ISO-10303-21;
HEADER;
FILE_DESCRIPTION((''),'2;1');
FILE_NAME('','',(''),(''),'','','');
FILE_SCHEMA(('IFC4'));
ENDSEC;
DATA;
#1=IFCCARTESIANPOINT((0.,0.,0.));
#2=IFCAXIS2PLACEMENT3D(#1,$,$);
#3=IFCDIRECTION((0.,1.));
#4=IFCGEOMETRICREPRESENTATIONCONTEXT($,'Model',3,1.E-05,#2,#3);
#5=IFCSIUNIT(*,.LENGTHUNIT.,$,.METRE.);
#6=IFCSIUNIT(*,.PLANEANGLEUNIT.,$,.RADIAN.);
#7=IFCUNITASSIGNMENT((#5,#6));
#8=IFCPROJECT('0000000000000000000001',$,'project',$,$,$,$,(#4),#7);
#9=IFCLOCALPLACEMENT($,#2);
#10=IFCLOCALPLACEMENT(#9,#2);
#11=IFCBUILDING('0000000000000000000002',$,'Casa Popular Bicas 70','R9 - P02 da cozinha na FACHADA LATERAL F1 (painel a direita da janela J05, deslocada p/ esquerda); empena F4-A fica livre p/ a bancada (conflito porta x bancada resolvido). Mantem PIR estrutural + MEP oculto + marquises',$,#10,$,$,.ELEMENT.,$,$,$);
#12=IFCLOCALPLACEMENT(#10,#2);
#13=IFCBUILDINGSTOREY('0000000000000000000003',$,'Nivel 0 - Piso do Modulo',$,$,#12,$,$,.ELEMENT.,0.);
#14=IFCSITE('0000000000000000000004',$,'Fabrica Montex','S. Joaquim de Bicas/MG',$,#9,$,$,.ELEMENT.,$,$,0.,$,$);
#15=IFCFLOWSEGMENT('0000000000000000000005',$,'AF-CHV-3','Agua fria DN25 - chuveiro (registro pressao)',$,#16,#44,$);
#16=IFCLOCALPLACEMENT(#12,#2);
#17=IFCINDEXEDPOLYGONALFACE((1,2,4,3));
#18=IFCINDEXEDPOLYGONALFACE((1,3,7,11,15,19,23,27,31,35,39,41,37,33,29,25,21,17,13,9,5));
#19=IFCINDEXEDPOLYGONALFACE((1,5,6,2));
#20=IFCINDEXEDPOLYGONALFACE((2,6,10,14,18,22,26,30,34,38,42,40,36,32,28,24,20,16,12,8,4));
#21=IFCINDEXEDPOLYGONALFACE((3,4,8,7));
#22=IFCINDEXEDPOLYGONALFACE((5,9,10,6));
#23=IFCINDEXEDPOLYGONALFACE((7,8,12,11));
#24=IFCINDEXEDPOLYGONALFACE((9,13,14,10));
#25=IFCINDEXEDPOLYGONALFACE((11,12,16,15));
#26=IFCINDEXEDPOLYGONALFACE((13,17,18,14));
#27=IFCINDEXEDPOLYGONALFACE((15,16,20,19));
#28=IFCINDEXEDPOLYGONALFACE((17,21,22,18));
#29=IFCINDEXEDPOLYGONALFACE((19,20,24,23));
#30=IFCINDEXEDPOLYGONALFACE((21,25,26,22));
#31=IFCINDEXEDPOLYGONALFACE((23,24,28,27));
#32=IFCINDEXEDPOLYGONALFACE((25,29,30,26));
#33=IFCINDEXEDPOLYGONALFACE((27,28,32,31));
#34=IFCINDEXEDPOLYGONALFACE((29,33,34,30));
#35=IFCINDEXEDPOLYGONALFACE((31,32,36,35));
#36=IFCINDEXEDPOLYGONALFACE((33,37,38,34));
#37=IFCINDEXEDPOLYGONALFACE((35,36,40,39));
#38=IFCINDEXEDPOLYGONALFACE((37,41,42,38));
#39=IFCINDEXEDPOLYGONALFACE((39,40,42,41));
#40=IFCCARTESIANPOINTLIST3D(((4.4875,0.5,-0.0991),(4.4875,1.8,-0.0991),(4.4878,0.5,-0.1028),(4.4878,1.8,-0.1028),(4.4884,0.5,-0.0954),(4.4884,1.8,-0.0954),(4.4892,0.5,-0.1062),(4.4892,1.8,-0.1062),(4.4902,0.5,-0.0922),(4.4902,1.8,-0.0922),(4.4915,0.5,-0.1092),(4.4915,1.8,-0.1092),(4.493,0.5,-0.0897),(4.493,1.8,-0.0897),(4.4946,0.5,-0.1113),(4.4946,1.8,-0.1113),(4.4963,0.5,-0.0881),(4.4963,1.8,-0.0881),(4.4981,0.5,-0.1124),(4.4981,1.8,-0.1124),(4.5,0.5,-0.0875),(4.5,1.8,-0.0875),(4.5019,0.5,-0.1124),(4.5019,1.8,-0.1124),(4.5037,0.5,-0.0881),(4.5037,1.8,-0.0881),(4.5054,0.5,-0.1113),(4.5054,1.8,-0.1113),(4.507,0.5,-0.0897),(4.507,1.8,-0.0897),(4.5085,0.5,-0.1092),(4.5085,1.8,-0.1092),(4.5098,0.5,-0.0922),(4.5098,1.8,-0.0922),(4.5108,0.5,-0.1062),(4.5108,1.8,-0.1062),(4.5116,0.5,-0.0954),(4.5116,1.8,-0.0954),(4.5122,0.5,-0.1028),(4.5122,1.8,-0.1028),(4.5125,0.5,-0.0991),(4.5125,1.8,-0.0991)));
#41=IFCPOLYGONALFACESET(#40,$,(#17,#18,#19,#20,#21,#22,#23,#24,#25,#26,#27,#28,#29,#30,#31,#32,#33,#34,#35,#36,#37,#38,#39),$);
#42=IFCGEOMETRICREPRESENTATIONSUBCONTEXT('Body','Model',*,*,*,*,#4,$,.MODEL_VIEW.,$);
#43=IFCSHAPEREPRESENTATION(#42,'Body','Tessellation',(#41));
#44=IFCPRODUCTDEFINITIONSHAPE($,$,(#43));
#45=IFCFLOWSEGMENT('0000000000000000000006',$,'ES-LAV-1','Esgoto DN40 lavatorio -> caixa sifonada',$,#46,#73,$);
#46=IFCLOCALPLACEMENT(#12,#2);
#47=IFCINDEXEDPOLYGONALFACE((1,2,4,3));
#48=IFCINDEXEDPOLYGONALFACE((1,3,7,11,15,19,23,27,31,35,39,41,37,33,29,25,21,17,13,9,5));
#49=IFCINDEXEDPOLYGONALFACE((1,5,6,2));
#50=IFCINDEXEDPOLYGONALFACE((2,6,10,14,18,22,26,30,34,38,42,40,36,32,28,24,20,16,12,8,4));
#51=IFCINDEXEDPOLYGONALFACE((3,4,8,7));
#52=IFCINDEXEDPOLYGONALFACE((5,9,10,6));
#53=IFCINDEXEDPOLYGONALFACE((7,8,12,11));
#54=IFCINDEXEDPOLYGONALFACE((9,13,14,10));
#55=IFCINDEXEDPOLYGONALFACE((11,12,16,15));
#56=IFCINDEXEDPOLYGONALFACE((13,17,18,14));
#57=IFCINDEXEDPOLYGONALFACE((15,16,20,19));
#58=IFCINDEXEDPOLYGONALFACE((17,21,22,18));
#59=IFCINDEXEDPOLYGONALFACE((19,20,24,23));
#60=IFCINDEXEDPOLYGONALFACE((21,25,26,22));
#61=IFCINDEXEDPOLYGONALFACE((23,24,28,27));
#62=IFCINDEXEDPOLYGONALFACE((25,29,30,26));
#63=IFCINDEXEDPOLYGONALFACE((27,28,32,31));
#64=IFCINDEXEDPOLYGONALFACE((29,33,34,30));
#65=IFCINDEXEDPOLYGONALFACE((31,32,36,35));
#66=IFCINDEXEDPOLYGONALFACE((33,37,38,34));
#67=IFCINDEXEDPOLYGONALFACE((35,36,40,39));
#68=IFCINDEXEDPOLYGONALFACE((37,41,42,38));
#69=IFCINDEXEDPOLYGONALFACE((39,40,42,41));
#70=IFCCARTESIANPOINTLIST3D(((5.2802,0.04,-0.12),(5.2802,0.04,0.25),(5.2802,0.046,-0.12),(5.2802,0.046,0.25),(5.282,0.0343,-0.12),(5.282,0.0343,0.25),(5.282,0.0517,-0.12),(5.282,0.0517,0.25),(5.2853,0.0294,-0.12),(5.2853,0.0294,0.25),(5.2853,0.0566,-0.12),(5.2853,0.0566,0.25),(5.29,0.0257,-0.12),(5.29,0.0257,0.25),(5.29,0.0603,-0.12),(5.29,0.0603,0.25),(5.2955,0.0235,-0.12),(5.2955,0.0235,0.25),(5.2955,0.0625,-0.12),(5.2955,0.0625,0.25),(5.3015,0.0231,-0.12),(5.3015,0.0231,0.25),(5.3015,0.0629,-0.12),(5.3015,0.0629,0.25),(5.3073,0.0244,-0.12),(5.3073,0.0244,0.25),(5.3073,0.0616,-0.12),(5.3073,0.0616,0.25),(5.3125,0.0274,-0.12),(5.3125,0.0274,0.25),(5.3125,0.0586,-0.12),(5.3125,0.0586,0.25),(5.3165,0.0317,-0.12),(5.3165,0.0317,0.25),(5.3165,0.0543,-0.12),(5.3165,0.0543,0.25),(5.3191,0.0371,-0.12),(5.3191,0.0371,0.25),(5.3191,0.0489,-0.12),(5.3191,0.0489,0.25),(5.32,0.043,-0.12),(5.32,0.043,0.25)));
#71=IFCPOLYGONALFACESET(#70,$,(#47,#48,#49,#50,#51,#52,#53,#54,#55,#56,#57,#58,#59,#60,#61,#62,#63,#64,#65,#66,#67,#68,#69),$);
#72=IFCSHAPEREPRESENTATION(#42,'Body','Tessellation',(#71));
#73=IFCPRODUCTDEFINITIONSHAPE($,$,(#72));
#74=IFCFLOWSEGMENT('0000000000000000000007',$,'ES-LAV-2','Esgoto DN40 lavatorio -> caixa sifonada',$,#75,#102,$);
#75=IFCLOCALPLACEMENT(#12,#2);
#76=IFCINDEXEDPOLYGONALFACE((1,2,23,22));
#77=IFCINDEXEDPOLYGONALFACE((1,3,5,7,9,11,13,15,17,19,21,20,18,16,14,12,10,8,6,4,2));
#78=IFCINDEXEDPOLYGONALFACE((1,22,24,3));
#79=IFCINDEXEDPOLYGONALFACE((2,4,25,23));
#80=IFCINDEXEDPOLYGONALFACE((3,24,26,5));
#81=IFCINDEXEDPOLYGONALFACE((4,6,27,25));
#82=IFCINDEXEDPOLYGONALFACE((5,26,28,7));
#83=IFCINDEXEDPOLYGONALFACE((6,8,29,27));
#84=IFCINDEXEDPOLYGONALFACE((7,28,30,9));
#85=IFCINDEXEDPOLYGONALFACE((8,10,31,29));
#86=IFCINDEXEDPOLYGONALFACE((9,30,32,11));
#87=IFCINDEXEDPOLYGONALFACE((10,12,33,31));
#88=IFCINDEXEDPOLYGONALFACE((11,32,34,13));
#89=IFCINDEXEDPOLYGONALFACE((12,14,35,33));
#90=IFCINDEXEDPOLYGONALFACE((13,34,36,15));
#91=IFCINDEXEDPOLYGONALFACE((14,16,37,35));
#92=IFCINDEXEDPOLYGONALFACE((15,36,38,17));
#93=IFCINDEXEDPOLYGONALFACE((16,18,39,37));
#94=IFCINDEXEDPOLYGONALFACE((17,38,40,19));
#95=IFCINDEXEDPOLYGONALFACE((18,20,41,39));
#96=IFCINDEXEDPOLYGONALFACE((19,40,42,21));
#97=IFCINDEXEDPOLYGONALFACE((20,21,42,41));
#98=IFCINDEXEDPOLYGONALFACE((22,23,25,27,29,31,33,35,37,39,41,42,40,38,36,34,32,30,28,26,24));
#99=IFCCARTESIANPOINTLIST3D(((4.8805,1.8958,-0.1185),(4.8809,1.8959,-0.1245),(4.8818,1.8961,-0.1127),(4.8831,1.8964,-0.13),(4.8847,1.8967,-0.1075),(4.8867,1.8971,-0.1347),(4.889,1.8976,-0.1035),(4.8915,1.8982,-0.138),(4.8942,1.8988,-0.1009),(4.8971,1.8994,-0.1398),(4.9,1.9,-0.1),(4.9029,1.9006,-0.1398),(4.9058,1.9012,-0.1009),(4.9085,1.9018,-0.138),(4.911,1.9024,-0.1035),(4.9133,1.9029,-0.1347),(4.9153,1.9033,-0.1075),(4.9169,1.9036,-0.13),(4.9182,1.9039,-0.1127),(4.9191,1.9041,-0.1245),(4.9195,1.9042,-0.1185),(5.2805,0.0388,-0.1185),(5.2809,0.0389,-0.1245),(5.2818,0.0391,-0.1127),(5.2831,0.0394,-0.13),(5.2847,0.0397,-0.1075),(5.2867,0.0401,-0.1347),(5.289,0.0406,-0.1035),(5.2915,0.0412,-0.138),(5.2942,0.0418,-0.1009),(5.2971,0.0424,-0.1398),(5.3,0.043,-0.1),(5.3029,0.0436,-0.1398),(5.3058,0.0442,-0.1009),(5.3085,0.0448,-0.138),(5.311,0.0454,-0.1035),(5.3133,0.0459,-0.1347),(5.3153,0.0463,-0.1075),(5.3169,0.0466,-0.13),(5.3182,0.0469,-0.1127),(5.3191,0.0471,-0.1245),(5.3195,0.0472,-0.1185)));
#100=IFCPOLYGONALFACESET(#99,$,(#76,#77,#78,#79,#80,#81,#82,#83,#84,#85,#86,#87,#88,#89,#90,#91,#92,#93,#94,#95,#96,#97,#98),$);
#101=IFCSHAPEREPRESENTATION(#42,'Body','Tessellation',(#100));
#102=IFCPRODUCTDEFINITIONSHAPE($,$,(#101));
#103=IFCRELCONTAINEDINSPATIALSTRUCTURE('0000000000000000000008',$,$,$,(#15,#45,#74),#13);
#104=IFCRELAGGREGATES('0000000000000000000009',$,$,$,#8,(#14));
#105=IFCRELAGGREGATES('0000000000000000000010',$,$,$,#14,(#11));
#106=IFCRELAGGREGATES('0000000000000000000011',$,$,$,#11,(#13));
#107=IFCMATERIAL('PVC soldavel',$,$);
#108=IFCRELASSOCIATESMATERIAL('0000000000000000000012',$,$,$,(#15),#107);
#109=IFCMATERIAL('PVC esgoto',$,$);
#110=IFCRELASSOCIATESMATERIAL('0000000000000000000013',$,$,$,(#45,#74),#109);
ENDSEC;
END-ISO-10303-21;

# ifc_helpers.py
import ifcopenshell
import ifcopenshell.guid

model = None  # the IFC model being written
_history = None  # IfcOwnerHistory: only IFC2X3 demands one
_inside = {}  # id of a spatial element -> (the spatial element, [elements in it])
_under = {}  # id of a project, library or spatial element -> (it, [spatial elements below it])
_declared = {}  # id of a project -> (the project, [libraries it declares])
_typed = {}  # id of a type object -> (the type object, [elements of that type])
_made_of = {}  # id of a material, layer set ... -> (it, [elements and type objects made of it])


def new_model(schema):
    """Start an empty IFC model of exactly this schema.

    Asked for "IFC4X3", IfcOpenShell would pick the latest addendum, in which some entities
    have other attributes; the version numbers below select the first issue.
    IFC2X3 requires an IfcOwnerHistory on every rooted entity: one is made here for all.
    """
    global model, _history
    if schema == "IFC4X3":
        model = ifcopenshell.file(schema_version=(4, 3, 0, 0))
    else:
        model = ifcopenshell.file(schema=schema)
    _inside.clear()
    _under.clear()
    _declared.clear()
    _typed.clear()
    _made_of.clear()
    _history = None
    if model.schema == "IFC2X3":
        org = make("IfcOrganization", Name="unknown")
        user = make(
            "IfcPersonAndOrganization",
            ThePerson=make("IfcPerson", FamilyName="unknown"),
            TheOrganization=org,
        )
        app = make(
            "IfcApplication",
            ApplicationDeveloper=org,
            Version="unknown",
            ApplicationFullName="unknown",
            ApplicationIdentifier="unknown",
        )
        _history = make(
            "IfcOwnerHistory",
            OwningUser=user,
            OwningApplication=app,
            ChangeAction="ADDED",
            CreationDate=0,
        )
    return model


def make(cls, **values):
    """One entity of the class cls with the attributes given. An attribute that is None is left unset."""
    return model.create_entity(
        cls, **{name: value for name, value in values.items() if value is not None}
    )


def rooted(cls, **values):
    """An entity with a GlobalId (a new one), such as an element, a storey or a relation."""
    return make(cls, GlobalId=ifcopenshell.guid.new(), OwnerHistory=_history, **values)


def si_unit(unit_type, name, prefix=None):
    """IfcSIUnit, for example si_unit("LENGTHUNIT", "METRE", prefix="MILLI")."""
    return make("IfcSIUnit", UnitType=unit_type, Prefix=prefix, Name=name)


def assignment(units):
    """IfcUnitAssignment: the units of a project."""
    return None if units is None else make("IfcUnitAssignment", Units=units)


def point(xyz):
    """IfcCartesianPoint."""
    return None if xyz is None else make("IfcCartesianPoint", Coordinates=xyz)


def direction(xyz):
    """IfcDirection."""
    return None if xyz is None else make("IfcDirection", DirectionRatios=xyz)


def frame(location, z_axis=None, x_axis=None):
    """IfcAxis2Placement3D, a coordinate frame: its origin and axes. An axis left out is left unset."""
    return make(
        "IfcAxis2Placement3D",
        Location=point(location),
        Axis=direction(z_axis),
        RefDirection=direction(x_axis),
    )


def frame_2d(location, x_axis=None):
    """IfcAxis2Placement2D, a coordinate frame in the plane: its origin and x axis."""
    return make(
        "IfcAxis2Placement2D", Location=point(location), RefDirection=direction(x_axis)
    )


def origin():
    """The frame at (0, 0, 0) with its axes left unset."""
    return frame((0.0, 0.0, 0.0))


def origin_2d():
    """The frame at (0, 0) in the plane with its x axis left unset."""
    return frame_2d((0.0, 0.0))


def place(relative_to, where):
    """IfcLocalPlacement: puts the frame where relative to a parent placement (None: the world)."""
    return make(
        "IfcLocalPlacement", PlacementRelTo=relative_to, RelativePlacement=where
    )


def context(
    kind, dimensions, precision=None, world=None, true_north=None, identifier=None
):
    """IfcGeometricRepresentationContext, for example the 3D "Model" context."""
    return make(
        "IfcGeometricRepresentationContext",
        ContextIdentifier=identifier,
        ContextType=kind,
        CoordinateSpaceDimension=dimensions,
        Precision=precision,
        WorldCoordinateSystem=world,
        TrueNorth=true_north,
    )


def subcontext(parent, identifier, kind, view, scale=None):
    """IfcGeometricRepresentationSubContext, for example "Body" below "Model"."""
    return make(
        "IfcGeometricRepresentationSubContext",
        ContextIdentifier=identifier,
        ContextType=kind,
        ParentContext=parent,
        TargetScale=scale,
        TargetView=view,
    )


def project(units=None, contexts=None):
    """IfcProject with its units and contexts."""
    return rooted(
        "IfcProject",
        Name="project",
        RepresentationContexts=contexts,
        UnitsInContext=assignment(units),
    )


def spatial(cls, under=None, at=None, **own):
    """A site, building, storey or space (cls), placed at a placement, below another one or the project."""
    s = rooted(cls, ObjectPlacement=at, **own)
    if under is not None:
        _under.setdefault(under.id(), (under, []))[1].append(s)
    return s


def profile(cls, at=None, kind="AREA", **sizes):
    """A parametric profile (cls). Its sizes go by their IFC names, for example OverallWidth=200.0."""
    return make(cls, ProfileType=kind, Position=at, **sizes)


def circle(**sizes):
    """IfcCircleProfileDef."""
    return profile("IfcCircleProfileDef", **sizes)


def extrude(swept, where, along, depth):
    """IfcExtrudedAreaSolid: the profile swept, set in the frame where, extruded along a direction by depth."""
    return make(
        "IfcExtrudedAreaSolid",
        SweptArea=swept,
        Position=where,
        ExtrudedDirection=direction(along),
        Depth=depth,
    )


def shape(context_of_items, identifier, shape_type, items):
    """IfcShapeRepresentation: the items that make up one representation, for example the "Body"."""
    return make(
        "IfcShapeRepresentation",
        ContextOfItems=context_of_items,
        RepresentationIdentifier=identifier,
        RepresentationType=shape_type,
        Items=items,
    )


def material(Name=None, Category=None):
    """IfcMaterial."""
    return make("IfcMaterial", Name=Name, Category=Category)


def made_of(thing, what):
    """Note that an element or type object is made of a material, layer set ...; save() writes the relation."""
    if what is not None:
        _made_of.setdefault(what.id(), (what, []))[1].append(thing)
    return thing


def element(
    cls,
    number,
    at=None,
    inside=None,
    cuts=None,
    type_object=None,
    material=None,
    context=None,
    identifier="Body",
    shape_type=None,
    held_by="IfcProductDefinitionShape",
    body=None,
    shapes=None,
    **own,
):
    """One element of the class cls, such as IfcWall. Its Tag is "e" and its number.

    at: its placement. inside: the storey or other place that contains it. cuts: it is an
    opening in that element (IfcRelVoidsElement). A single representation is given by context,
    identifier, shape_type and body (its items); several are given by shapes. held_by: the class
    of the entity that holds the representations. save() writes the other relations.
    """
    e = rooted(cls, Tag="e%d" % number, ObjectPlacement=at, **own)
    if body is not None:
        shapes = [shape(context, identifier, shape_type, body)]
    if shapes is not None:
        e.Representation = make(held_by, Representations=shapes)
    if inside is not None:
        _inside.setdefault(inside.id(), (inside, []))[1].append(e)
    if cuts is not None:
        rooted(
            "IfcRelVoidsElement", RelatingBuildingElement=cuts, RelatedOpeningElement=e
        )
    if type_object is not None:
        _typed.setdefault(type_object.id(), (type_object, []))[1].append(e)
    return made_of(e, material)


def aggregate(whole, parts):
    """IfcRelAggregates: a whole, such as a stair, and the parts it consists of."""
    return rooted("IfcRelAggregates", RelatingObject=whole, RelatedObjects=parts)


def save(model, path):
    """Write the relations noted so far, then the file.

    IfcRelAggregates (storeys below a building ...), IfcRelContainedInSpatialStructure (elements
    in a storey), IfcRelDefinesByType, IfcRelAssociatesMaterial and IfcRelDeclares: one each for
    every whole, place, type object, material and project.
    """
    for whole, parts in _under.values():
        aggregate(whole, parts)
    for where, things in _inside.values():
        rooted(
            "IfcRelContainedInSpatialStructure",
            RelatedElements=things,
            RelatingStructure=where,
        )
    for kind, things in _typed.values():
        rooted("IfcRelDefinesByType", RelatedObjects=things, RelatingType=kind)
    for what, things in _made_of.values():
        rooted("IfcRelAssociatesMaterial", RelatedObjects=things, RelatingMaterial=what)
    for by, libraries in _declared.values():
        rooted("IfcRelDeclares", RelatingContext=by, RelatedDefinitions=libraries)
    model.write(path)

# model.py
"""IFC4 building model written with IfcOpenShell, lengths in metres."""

from ifc_helpers import new_model, si_unit, direction, frame, origin, origin_2d, place, context, subcontext, project, spatial, circle, extrude, material, element, save


model = new_model("IFC4")

# Units and contexts
model_context = context("Model", 3, precision=1e-05, world=origin(), true_north=direction((0.0, 1.0)))
body_context = subcontext(model_context, "Body", "Model", "MODEL_VIEW")
ifc_project = project(units=[si_unit("LENGTHUNIT", "METRE"), si_unit("PLANEANGLEUNIT", "RADIAN")], contexts=[model_context])

# Site, building, storey
site_placement = place(None, origin())
site = spatial("IfcSite", under=ifc_project, at=site_placement, Name="Fabrica Montex", Description="S. Joaquim de Bicas/MG", CompositionType="ELEMENT", RefElevation=0.0)
building_placement = place(site_placement, origin())
building = spatial("IfcBuilding", under=site, at=building_placement, Name="Casa Popular Bicas 70", Description="R9 - P02 da cozinha na FACHADA LATERAL F1 (painel a direita da janela J05, deslocada p/ esquerda); empena F4-A fica livre p/ a bancada (conflito porta x bancada resolvido). Mantem PIR estrutural + MEP oculto + marquises", CompositionType="ELEMENT")
storey_placement = place(building_placement, origin())
storey = spatial("IfcBuildingStorey", under=building, at=storey_placement, Name="Nivel 0 - Piso do Modulo", CompositionType="ELEMENT", Elevation=0.0)

# Flow segments
ifc_material_1 = material(Name="PVC soldavel")
flow_segment_1_placement = place(storey_placement, frame((4.5, 0.5, -0.1), z_axis=(0.0, 1.0, 0.0), x_axis=(0.0, 0.0, 1.0)))
element("IfcFlowSegment", 1, at=flow_segment_1_placement, inside=storey, material=ifc_material_1, Name="AF-CHV-3", Description="Agua fria DN25 - chuveiro (registro pressao)", context=body_context, shape_type="SweptSolid", body=[
    extrude(circle(Radius=0.0125, at=origin_2d()), origin(), (0.0, 0.0, 1.0), 1.3),
])
ifc_material_2 = material(Name="PVC esgoto")
flow_segment_2_placement = place(storey_placement, frame((5.3, 0.043, 0.25), z_axis=(0.0, 0.0, -1.0), x_axis=(1.0, 0.0, 0.0)))
element("IfcFlowSegment", 2, at=flow_segment_2_placement, inside=storey, material=ifc_material_2, Name="ES-LAV-1", Description="Esgoto DN40 lavatorio -> caixa sifonada", context=body_context, shape_type="SweptSolid", body=[
    extrude(circle(Radius=0.02, at=origin_2d()), origin(), (0.0, 0.0, 1.0), 0.37),
])
flow_segment_3_placement = place(storey_placement, frame((5.3, 0.043, -0.12), z_axis=(-0.210572, 0.977578, 0.0), x_axis=(0.0, 0.0, 1.0)))
element("IfcFlowSegment", 3, at=flow_segment_3_placement, inside=storey, material=ifc_material_2, Name="ES-LAV-2", Description="Esgoto DN40 lavatorio -> caixa sifonada", context=body_context, shape_type="SweptSolid", body=[
    extrude(circle(Radius=0.02, at=origin_2d()), origin(), (0.0, 0.0, 1.0), 1.8996),
])

save(model, "model.ifc")
